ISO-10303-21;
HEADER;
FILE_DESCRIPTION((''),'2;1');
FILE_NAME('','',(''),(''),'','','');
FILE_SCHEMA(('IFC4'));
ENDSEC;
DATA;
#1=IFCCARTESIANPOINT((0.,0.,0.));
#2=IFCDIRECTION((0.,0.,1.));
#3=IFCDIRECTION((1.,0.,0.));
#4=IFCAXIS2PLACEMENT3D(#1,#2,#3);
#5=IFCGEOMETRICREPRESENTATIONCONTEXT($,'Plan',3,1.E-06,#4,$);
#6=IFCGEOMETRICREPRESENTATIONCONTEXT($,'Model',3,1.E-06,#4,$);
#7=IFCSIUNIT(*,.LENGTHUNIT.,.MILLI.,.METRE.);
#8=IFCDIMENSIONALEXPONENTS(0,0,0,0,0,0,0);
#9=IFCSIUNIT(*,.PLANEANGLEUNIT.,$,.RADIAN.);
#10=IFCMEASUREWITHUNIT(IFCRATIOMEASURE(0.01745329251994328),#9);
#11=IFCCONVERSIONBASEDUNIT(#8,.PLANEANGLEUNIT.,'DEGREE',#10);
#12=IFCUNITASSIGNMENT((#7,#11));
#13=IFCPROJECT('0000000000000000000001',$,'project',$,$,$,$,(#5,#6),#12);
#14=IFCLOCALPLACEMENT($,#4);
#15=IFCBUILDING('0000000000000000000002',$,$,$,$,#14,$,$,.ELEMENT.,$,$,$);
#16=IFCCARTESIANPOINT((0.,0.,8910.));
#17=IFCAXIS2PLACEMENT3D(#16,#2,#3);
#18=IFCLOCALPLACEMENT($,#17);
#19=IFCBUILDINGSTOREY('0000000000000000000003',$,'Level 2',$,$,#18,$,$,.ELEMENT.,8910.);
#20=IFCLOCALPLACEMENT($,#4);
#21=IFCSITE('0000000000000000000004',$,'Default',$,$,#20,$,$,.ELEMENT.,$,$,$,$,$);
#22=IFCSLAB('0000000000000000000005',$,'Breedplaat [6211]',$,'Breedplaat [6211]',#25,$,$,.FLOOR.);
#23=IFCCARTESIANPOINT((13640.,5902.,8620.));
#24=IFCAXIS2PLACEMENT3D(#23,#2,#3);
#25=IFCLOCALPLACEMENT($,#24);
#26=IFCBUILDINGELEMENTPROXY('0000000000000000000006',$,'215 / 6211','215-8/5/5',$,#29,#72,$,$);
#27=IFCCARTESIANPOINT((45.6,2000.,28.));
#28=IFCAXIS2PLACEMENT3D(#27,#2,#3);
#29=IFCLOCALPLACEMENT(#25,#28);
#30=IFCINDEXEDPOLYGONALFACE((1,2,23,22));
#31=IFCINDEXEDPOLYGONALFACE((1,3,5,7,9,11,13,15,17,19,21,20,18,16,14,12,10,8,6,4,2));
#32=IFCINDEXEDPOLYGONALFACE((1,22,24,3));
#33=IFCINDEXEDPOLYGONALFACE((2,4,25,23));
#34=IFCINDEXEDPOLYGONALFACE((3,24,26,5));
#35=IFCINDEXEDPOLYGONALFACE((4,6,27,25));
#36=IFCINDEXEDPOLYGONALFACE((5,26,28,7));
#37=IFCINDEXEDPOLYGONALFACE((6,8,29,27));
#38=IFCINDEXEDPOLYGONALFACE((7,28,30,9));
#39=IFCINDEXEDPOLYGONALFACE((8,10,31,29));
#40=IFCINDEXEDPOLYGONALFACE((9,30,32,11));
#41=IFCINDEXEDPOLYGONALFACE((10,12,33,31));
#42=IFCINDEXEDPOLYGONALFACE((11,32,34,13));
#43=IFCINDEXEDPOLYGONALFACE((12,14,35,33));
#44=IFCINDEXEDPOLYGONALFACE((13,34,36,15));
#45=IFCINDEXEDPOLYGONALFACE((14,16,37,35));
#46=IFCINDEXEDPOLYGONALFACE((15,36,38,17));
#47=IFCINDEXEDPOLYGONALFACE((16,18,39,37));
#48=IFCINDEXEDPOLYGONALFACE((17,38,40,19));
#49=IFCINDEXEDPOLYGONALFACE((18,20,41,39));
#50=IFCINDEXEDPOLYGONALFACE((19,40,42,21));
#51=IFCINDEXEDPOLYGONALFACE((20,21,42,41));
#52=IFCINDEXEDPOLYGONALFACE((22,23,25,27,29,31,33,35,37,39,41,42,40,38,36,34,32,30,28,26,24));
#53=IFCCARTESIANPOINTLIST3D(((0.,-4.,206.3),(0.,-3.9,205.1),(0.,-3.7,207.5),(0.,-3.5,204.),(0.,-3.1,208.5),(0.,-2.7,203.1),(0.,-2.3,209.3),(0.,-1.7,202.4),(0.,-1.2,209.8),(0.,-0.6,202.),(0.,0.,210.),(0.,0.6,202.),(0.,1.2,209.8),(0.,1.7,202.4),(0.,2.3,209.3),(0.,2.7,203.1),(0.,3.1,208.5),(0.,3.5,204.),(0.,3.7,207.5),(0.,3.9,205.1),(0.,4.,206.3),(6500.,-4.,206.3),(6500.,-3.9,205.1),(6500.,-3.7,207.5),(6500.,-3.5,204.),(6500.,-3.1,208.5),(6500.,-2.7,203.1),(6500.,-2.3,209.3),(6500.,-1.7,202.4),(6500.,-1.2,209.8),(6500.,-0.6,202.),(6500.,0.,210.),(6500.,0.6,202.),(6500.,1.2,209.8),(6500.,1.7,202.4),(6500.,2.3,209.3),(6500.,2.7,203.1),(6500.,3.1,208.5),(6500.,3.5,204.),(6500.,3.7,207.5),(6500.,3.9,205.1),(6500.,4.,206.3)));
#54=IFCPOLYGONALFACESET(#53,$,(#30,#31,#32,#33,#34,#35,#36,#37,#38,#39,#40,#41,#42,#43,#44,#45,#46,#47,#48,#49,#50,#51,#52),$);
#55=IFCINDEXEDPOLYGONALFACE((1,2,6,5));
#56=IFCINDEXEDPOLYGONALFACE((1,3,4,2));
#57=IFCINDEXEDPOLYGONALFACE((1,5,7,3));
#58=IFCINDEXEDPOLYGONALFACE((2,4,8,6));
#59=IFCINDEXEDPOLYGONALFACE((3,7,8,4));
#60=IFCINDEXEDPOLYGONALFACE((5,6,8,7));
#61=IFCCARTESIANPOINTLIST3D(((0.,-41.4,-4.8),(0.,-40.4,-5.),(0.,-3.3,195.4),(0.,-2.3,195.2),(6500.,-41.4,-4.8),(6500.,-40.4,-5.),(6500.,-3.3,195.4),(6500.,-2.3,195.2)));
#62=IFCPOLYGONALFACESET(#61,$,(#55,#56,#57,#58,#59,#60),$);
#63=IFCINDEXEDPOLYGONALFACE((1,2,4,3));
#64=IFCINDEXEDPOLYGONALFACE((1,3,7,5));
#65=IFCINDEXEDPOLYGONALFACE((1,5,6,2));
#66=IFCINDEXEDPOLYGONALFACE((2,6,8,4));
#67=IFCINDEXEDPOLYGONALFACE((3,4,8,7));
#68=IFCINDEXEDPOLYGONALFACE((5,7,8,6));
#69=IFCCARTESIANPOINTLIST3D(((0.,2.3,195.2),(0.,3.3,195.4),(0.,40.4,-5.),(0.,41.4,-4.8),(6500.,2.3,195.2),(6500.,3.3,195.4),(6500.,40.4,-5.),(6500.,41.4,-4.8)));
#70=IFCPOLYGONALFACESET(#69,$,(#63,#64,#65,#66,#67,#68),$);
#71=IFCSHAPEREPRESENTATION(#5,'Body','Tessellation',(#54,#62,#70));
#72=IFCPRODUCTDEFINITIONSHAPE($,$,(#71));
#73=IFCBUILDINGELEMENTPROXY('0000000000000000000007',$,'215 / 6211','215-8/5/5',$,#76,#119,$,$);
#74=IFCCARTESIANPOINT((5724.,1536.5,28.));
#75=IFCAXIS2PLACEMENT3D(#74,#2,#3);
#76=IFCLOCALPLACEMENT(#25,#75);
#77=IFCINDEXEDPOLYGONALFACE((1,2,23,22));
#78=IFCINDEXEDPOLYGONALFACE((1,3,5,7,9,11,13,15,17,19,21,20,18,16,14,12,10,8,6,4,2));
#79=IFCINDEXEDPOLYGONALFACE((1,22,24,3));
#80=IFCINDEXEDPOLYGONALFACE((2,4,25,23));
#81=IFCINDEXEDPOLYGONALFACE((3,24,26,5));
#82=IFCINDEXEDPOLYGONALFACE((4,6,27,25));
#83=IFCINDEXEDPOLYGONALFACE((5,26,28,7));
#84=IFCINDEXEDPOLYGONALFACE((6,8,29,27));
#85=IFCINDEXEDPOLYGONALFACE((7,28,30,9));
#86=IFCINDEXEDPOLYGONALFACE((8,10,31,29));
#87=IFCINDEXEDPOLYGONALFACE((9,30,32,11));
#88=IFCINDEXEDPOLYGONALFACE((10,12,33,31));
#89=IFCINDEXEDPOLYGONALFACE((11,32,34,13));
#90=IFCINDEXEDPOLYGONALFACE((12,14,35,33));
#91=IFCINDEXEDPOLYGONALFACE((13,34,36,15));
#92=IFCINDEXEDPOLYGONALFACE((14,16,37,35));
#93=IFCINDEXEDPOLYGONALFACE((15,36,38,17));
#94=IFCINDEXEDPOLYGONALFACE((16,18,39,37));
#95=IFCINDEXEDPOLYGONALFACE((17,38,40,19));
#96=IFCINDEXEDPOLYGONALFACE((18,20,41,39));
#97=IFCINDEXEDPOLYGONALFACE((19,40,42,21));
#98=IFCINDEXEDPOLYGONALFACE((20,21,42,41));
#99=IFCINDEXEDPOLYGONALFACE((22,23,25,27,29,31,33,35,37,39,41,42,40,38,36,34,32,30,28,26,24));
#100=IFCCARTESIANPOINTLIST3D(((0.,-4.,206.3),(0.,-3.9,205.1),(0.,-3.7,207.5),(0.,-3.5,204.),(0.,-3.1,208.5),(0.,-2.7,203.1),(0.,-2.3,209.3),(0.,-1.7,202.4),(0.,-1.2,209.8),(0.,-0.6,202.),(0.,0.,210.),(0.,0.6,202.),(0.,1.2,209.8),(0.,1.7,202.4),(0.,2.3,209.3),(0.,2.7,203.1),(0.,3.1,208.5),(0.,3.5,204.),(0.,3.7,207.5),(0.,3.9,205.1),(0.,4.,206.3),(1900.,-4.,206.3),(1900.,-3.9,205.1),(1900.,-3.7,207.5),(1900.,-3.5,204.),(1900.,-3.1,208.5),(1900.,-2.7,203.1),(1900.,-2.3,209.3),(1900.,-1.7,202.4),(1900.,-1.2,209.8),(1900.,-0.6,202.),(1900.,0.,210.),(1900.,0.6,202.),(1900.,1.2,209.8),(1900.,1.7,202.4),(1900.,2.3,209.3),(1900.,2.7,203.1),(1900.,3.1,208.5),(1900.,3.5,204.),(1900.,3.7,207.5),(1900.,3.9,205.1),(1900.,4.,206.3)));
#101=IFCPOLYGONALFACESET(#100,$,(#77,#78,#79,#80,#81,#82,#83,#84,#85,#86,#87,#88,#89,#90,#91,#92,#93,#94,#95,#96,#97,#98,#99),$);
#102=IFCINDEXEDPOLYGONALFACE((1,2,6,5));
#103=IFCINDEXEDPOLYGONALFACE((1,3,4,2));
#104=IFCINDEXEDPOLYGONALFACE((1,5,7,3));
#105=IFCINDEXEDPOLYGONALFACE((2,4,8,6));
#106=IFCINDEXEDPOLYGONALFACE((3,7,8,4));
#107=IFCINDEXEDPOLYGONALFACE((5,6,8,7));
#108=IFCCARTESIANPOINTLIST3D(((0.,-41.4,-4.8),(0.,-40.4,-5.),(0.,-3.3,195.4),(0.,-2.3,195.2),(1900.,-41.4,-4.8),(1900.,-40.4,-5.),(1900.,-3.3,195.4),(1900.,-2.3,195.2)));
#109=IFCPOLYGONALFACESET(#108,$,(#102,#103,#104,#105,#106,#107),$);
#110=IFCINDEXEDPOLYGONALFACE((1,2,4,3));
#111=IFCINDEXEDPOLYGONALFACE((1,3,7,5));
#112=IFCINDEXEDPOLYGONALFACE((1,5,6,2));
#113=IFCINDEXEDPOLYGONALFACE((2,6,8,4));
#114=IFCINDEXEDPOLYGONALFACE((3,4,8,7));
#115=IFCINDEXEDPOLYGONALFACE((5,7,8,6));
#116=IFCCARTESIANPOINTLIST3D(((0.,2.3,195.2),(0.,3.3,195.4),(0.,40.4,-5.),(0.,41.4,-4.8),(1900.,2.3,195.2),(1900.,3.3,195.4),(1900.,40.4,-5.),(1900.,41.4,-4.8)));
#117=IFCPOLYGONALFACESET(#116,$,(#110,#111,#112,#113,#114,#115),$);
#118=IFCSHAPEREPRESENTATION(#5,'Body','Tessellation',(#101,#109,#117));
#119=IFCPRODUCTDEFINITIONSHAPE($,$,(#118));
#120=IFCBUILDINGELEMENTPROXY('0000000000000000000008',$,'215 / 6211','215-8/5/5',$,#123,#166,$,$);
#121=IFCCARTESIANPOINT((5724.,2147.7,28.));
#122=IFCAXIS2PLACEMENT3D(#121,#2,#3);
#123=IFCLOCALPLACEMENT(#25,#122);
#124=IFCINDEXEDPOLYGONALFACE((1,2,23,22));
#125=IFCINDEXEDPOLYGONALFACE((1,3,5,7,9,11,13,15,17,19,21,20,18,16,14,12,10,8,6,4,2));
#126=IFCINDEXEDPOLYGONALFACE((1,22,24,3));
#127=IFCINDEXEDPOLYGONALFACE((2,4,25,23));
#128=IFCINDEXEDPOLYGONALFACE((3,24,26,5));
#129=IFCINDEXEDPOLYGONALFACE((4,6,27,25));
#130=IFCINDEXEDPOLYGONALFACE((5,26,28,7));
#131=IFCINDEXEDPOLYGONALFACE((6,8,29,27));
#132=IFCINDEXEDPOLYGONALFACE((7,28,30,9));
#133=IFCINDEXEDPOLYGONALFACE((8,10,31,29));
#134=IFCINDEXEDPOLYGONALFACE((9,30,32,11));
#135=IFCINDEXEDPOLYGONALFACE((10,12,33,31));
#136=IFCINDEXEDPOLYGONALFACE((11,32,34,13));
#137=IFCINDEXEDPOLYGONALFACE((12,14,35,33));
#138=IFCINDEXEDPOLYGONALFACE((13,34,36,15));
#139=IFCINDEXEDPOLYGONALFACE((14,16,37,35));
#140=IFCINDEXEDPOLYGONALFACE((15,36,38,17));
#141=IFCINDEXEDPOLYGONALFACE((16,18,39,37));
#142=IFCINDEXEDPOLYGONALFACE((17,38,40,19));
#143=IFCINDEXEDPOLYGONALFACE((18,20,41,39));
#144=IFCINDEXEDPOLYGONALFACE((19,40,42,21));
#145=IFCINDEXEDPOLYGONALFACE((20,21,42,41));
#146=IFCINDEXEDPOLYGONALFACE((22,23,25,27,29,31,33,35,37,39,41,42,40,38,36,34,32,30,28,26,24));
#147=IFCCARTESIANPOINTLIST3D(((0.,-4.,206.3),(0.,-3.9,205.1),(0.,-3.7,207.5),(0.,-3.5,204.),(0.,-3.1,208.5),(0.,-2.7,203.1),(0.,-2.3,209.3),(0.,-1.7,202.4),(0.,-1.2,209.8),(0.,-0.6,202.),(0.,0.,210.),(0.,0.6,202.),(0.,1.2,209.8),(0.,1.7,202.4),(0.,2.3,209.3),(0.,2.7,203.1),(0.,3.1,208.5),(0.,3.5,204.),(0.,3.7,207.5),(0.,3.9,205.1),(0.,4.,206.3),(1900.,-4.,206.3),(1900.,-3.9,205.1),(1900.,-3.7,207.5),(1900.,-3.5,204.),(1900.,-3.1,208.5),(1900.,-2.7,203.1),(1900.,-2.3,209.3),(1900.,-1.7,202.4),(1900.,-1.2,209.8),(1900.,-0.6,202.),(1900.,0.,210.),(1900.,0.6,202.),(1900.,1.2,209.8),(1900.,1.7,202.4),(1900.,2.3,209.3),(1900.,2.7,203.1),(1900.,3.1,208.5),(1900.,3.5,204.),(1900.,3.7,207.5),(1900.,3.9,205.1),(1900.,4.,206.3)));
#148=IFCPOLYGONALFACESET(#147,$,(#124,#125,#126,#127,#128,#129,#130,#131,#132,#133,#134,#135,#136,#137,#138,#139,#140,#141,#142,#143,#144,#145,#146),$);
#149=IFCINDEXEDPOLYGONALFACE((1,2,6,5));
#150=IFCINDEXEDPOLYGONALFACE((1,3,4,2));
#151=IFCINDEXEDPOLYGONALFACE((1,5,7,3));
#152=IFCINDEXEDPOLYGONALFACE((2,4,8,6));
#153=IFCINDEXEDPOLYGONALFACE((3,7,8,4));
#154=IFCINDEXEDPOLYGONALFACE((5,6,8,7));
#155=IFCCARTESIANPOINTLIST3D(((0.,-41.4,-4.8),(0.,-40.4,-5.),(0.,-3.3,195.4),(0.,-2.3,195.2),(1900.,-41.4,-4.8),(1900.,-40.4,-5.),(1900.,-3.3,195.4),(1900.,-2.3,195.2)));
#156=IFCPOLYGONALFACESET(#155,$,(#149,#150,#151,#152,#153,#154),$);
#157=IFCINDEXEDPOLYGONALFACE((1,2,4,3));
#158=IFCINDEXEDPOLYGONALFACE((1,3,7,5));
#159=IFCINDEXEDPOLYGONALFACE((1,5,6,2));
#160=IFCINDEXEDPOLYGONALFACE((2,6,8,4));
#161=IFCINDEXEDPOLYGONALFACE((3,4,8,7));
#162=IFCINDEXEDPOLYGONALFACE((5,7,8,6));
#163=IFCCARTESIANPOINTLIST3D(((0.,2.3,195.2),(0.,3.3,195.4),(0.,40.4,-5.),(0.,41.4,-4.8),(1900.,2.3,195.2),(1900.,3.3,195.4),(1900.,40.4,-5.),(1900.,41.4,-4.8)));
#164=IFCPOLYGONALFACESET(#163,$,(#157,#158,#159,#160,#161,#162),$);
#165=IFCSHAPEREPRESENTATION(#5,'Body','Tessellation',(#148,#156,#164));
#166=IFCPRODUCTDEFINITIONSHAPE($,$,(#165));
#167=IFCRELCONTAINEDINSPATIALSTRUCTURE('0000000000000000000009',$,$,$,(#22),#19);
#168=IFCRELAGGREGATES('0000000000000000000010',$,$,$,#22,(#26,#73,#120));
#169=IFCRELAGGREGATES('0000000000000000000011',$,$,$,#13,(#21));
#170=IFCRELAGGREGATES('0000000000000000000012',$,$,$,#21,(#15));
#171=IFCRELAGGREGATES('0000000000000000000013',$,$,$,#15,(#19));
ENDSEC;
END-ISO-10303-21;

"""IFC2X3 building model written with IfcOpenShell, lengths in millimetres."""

from ifc_helpers import new_model, entity, si_unit, converted_unit, frame, origin_with_axes, origin_2d_with_axis, place, context, project, spatial, rectangle, circle, extrude, element, aggregate, save


model = new_model("IFC2X3")

# Units and contexts
plan_context = context("Plan", 3, precision=1e-06, world=origin_with_axes())
model_context = context("Model", 3, precision=1e-06, world=origin_with_axes())
ifc_project = project(units=[si_unit("LENGTHUNIT", "METRE", prefix="MILLI"), converted_unit("PLANEANGLEUNIT", "DEGREE", entity("IfcRatioMeasure", 0.01745329251994328), si_unit("PLANEANGLEUNIT", "RADIAN"), dimensions=[0, 0, 0, 0, 0, 0, 0])], contexts=[plan_context, model_context])

# Site, building, storey
site_placement = place(None, origin_with_axes())
site = spatial("IfcSite", under=ifc_project, at=site_placement, Name="Default", CompositionType="ELEMENT")
building_placement = place(None, origin_with_axes())
building = spatial("IfcBuilding", under=site, at=building_placement, CompositionType="ELEMENT")
storey_placement = place(None, frame((0.0, 0.0, 8910.0), z_axis=(0.0, 0.0, 1.0), x_axis=(1.0, 0.0, 0.0)))
storey = spatial("IfcBuildingStorey", under=building, at=storey_placement, Name="Level 2", CompositionType="ELEMENT", Elevation=8910.0)

# Slab, building element proxies
slab_1_placement = place(None, frame((13640.0, 5902.0, 8620.0), z_axis=(0.0, 0.0, 1.0), x_axis=(1.0, 0.0, 0.0)))
slab_1 = element("IfcSlab", 1, at=slab_1_placement, inside=storey, Name="Breedplaat [6211]", ObjectType="Breedplaat [6211]", PredefinedType="FLOOR")
proxy_1_placement = place(slab_1_placement, frame((45.6, 2000.0, 28.0), z_axis=(0.0, 0.0, 1.0), x_axis=(1.0, 0.0, 0.0)))
proxy_1 = element("IfcBuildingElementProxy", 2, at=proxy_1_placement, Name="215 / 6211", Description="215-8/5/5", context=plan_context, shape_type="SweptSolid", body=[
    extrude(circle(Radius=4.0, at=origin_2d_with_axis()), frame((0.0, 0.0, 206.0), z_axis=(1.0, 0.0, 0.0), x_axis=(0.0, 0.0, 1.0)), (0.0, 0.0, 1.0), 6500.0),
    extrude(rectangle(XDim=203.8, YDim=1.0, at=origin_2d_with_axis()), frame((0.0, -21.9, 95.2), z_axis=(1.0, 0.0, 0.0), x_axis=(0.0, 0.187112, 0.982339)), (0.0, 0.0, 1.0), 6500.0),
    extrude(rectangle(XDim=203.8, YDim=1.0, at=origin_2d_with_axis()), frame((0.0, 21.9, 95.2), z_axis=(1.0, 0.0, 0.0), x_axis=(0.0, -0.187112, 0.982339)), (0.0, 0.0, 1.0), 6500.0),
])
proxy_2_placement = place(slab_1_placement, frame((5724.0, 1536.5, 28.0), z_axis=(0.0, 0.0, 1.0), x_axis=(1.0, 0.0, 0.0)))
proxy_2 = element("IfcBuildingElementProxy", 3, at=proxy_2_placement, Name="215 / 6211", Description="215-8/5/5", context=plan_context, shape_type="SweptSolid", body=[
    extrude(circle(Radius=4.0, at=origin_2d_with_axis()), frame((0.0, 0.0, 206.0), z_axis=(1.0, 0.0, 0.0), x_axis=(0.0, 0.0, 1.0)), (0.0, 0.0, 1.0), 1900.0),
    extrude(rectangle(XDim=203.8, YDim=1.0, at=origin_2d_with_axis()), frame((0.0, -21.9, 95.2), z_axis=(1.0, 0.0, 0.0), x_axis=(0.0, 0.187112, 0.982339)), (0.0, 0.0, 1.0), 1900.0),
    extrude(rectangle(XDim=203.8, YDim=1.0, at=origin_2d_with_axis()), frame((0.0, 21.9, 95.2), z_axis=(1.0, 0.0, 0.0), x_axis=(0.0, -0.187112, 0.982339)), (0.0, 0.0, 1.0), 1900.0),
])
proxy_3_placement = place(slab_1_placement, frame((5724.0, 2147.7, 28.0), z_axis=(0.0, 0.0, 1.0), x_axis=(1.0, 0.0, 0.0)))
proxy_3 = element("IfcBuildingElementProxy", 4, at=proxy_3_placement, Name="215 / 6211", Description="215-8/5/5", context=plan_context, shape_type="SweptSolid", body=[
    extrude(circle(Radius=4.0, at=origin_2d_with_axis()), frame((0.0, 0.0, 206.0), z_axis=(1.0, 0.0, 0.0), x_axis=(0.0, 0.0, 1.0)), (0.0, 0.0, 1.0), 1900.0),
    extrude(rectangle(XDim=203.8, YDim=1.0, at=origin_2d_with_axis()), frame((0.0, -21.9, 95.2), z_axis=(1.0, 0.0, 0.0), x_axis=(0.0, 0.187112, 0.982339)), (0.0, 0.0, 1.0), 1900.0),
    extrude(rectangle(XDim=203.8, YDim=1.0, at=origin_2d_with_axis()), frame((0.0, 21.9, 95.2), z_axis=(1.0, 0.0, 0.0), x_axis=(0.0, -0.187112, 0.982339)), (0.0, 0.0, 1.0), 1900.0),
])
aggregate(slab_1, [proxy_1, proxy_2, proxy_3])

save(model, "model.ifc")
